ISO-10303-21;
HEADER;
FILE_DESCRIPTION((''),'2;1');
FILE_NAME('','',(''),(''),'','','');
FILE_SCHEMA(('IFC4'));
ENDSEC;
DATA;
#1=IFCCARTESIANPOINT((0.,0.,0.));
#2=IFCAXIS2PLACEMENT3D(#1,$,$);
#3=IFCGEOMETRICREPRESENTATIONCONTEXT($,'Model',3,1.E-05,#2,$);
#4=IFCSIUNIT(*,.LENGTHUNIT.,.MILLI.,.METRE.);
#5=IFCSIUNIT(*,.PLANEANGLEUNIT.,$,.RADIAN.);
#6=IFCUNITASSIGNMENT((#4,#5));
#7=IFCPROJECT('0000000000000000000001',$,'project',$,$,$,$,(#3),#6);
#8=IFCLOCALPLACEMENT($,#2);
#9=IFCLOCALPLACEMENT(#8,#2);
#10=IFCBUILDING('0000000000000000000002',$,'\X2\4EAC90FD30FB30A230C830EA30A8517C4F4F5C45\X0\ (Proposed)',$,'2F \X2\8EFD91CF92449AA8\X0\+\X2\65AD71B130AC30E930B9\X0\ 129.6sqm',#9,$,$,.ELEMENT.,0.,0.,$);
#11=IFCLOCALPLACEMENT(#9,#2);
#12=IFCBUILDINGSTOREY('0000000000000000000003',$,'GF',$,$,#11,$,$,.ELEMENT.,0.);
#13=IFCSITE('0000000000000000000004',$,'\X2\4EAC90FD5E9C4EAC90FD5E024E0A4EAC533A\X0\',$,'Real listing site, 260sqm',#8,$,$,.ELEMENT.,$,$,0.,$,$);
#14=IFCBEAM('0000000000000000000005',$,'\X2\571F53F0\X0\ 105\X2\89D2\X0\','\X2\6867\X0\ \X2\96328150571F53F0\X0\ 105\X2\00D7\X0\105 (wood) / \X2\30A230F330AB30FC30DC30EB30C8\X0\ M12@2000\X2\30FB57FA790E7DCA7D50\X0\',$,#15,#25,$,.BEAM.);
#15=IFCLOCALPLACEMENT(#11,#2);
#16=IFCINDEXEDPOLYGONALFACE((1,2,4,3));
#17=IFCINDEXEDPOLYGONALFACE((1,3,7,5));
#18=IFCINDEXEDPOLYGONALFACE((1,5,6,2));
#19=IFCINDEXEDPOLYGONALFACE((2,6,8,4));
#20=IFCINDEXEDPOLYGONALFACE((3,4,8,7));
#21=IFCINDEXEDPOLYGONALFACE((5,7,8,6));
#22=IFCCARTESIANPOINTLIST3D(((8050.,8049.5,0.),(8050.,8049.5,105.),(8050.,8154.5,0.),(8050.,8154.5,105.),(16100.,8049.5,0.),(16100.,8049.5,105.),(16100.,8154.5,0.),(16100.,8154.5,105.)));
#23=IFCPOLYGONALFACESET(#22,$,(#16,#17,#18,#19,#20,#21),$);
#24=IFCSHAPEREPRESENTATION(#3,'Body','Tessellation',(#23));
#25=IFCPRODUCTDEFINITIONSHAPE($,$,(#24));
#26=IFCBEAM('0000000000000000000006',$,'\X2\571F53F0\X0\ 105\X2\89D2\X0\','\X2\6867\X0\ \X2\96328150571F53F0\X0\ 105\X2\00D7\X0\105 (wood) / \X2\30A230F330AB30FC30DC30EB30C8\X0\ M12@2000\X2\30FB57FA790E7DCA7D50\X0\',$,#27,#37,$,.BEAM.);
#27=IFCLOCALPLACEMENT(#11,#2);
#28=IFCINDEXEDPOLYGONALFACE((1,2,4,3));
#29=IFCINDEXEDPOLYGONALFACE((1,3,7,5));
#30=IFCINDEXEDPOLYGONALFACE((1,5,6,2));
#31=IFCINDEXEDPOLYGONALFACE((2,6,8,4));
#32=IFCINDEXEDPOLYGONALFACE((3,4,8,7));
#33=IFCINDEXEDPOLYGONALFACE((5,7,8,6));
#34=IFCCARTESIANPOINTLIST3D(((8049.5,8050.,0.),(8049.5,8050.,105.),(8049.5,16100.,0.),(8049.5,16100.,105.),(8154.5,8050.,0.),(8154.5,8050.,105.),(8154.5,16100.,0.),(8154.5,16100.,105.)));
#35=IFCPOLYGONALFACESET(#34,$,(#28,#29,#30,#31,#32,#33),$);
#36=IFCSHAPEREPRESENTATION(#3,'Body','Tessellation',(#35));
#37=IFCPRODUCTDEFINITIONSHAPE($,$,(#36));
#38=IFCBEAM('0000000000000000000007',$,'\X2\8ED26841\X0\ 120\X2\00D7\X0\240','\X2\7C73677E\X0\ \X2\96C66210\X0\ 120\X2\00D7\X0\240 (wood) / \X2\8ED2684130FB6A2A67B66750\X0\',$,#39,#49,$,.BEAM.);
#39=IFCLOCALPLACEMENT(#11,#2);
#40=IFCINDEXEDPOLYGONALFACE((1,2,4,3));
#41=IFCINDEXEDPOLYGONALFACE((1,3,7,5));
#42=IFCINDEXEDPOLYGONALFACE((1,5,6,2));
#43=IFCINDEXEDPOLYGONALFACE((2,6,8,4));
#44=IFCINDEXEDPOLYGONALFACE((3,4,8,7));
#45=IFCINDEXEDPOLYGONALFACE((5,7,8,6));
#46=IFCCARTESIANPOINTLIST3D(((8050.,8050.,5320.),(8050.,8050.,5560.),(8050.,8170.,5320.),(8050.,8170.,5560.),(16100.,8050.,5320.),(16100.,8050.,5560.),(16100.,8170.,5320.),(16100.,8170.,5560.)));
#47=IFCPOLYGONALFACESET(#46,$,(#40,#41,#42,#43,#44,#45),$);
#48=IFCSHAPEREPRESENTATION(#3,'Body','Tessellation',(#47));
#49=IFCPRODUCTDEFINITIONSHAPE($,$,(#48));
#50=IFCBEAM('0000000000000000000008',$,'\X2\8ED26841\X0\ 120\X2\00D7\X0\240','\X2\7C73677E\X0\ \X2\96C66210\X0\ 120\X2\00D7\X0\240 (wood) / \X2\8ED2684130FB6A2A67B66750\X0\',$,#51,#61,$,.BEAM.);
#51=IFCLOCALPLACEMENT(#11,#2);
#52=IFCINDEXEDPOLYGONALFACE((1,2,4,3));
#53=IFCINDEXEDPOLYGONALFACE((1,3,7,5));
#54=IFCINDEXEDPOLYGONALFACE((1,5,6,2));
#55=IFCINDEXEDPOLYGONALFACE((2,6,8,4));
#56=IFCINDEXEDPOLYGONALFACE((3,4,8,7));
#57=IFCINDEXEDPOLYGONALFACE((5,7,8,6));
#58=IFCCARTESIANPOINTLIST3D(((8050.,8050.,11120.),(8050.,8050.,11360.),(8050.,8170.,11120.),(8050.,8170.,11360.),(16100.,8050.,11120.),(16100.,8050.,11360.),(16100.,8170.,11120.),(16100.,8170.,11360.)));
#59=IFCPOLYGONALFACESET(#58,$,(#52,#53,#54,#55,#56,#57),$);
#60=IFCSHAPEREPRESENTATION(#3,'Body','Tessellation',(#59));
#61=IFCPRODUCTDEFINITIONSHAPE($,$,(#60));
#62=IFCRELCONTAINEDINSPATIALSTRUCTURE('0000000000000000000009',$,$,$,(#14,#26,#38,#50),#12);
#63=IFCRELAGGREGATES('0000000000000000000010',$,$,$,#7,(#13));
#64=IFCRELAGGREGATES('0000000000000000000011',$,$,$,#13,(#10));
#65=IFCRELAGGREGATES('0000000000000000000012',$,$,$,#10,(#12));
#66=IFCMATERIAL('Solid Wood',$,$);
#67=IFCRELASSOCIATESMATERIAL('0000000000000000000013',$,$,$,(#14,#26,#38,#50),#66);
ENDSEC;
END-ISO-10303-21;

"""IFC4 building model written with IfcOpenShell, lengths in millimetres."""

from ifc_helpers import new_model, si_unit, frame, frame_2d, origin, place, context, project, spatial, rectangle, extrude, material, element, save


model = new_model("IFC4")

# Units and contexts
model_context = context("Model", 3, precision=1e-05, world=origin())
ifc_project = project(units=[si_unit("LENGTHUNIT", "METRE", prefix="MILLI"), si_unit("PLANEANGLEUNIT", "RADIAN")], contexts=[model_context])

# Site, building, storey
site_placement = place(None, origin())
site = spatial("IfcSite", under=ifc_project, at=site_placement, Name="京都府京都市上京区", ObjectType="Real listing site, 260sqm", CompositionType="ELEMENT", RefElevation=0.0)
building_placement = place(site_placement, origin())
building = spatial("IfcBuilding", under=site, at=building_placement, Name="京都・アトリエ兼住居 (Proposed)", ObjectType="2F 軽量鉄骨+断熱ガラス 129.6sqm", CompositionType="ELEMENT", ElevationOfRefHeight=0.0, ElevationOfTerrain=0.0)
storey_placement = place(building_placement, origin())
storey = spatial("IfcBuildingStorey", under=building, at=storey_placement, Name="GF", CompositionType="ELEMENT", Elevation=0.0)

# Shared definitions
ifc_material_1 = material(Name="Solid Wood")

# Beams
beam_1_placement = place(storey_placement, frame((4025.0, 4025.0, 0.0)))
element("IfcBeam", 1, at=beam_1_placement, inside=storey, material=ifc_material_1, Name="土台 105角", Description="桧 防腐土台 105×105 (wood) / アンカーボルト M12@2000・基礎緊結", PredefinedType="BEAM", context=model_context, shape_type="SweptSolid", body=[
    extrude(rectangle(XDim=8050.0, YDim=105.0, at=frame_2d((4025.0, 52.0))), frame((4025.0, 4025.0, 0.0)), (0.0, 0.0, 1.0), 105.0),
])
beam_2_placement = place(storey_placement, frame((4025.0, 4025.0, 0.0)))
element("IfcBeam", 2, at=beam_2_placement, inside=storey, material=ifc_material_1, Name="土台 105角", Description="桧 防腐土台 105×105 (wood) / アンカーボルト M12@2000・基礎緊結", PredefinedType="BEAM", context=model_context, shape_type="SweptSolid", body=[
    extrude(rectangle(XDim=105.0, YDim=8050.0, at=frame_2d((52.0, 4025.0))), frame((4025.0, 4025.0, 0.0)), (0.0, 0.0, 1.0), 105.0),
])
beam_3_placement = place(storey_placement, frame((4025.0, 4025.0, 2660.0)))
element("IfcBeam", 3, at=beam_3_placement, inside=storey, material=ifc_material_1, Name="軒桁 120×240", Description="米松 集成 120×240 (wood) / 軒桁・横架材", PredefinedType="BEAM", context=model_context, shape_type="SweptSolid", body=[
    extrude(rectangle(XDim=8050.0, YDim=120.0, at=frame_2d((4025.0, 60.0))), frame((4025.0, 4025.0, 2660.0)), (0.0, 0.0, 1.0), 240.0),
])
beam_4_placement = place(storey_placement, frame((4025.0, 4025.0, 5560.0)))
element("IfcBeam", 4, at=beam_4_placement, inside=storey, material=ifc_material_1, Name="軒桁 120×240", Description="米松 集成 120×240 (wood) / 軒桁・横架材", PredefinedType="BEAM", context=model_context, shape_type="SweptSolid", body=[
    extrude(rectangle(XDim=8050.0, YDim=120.0, at=frame_2d((4025.0, 60.0))), frame((4025.0, 4025.0, 5560.0)), (0.0, 0.0, 1.0), 240.0),
])

save(model, "model.ifc")
